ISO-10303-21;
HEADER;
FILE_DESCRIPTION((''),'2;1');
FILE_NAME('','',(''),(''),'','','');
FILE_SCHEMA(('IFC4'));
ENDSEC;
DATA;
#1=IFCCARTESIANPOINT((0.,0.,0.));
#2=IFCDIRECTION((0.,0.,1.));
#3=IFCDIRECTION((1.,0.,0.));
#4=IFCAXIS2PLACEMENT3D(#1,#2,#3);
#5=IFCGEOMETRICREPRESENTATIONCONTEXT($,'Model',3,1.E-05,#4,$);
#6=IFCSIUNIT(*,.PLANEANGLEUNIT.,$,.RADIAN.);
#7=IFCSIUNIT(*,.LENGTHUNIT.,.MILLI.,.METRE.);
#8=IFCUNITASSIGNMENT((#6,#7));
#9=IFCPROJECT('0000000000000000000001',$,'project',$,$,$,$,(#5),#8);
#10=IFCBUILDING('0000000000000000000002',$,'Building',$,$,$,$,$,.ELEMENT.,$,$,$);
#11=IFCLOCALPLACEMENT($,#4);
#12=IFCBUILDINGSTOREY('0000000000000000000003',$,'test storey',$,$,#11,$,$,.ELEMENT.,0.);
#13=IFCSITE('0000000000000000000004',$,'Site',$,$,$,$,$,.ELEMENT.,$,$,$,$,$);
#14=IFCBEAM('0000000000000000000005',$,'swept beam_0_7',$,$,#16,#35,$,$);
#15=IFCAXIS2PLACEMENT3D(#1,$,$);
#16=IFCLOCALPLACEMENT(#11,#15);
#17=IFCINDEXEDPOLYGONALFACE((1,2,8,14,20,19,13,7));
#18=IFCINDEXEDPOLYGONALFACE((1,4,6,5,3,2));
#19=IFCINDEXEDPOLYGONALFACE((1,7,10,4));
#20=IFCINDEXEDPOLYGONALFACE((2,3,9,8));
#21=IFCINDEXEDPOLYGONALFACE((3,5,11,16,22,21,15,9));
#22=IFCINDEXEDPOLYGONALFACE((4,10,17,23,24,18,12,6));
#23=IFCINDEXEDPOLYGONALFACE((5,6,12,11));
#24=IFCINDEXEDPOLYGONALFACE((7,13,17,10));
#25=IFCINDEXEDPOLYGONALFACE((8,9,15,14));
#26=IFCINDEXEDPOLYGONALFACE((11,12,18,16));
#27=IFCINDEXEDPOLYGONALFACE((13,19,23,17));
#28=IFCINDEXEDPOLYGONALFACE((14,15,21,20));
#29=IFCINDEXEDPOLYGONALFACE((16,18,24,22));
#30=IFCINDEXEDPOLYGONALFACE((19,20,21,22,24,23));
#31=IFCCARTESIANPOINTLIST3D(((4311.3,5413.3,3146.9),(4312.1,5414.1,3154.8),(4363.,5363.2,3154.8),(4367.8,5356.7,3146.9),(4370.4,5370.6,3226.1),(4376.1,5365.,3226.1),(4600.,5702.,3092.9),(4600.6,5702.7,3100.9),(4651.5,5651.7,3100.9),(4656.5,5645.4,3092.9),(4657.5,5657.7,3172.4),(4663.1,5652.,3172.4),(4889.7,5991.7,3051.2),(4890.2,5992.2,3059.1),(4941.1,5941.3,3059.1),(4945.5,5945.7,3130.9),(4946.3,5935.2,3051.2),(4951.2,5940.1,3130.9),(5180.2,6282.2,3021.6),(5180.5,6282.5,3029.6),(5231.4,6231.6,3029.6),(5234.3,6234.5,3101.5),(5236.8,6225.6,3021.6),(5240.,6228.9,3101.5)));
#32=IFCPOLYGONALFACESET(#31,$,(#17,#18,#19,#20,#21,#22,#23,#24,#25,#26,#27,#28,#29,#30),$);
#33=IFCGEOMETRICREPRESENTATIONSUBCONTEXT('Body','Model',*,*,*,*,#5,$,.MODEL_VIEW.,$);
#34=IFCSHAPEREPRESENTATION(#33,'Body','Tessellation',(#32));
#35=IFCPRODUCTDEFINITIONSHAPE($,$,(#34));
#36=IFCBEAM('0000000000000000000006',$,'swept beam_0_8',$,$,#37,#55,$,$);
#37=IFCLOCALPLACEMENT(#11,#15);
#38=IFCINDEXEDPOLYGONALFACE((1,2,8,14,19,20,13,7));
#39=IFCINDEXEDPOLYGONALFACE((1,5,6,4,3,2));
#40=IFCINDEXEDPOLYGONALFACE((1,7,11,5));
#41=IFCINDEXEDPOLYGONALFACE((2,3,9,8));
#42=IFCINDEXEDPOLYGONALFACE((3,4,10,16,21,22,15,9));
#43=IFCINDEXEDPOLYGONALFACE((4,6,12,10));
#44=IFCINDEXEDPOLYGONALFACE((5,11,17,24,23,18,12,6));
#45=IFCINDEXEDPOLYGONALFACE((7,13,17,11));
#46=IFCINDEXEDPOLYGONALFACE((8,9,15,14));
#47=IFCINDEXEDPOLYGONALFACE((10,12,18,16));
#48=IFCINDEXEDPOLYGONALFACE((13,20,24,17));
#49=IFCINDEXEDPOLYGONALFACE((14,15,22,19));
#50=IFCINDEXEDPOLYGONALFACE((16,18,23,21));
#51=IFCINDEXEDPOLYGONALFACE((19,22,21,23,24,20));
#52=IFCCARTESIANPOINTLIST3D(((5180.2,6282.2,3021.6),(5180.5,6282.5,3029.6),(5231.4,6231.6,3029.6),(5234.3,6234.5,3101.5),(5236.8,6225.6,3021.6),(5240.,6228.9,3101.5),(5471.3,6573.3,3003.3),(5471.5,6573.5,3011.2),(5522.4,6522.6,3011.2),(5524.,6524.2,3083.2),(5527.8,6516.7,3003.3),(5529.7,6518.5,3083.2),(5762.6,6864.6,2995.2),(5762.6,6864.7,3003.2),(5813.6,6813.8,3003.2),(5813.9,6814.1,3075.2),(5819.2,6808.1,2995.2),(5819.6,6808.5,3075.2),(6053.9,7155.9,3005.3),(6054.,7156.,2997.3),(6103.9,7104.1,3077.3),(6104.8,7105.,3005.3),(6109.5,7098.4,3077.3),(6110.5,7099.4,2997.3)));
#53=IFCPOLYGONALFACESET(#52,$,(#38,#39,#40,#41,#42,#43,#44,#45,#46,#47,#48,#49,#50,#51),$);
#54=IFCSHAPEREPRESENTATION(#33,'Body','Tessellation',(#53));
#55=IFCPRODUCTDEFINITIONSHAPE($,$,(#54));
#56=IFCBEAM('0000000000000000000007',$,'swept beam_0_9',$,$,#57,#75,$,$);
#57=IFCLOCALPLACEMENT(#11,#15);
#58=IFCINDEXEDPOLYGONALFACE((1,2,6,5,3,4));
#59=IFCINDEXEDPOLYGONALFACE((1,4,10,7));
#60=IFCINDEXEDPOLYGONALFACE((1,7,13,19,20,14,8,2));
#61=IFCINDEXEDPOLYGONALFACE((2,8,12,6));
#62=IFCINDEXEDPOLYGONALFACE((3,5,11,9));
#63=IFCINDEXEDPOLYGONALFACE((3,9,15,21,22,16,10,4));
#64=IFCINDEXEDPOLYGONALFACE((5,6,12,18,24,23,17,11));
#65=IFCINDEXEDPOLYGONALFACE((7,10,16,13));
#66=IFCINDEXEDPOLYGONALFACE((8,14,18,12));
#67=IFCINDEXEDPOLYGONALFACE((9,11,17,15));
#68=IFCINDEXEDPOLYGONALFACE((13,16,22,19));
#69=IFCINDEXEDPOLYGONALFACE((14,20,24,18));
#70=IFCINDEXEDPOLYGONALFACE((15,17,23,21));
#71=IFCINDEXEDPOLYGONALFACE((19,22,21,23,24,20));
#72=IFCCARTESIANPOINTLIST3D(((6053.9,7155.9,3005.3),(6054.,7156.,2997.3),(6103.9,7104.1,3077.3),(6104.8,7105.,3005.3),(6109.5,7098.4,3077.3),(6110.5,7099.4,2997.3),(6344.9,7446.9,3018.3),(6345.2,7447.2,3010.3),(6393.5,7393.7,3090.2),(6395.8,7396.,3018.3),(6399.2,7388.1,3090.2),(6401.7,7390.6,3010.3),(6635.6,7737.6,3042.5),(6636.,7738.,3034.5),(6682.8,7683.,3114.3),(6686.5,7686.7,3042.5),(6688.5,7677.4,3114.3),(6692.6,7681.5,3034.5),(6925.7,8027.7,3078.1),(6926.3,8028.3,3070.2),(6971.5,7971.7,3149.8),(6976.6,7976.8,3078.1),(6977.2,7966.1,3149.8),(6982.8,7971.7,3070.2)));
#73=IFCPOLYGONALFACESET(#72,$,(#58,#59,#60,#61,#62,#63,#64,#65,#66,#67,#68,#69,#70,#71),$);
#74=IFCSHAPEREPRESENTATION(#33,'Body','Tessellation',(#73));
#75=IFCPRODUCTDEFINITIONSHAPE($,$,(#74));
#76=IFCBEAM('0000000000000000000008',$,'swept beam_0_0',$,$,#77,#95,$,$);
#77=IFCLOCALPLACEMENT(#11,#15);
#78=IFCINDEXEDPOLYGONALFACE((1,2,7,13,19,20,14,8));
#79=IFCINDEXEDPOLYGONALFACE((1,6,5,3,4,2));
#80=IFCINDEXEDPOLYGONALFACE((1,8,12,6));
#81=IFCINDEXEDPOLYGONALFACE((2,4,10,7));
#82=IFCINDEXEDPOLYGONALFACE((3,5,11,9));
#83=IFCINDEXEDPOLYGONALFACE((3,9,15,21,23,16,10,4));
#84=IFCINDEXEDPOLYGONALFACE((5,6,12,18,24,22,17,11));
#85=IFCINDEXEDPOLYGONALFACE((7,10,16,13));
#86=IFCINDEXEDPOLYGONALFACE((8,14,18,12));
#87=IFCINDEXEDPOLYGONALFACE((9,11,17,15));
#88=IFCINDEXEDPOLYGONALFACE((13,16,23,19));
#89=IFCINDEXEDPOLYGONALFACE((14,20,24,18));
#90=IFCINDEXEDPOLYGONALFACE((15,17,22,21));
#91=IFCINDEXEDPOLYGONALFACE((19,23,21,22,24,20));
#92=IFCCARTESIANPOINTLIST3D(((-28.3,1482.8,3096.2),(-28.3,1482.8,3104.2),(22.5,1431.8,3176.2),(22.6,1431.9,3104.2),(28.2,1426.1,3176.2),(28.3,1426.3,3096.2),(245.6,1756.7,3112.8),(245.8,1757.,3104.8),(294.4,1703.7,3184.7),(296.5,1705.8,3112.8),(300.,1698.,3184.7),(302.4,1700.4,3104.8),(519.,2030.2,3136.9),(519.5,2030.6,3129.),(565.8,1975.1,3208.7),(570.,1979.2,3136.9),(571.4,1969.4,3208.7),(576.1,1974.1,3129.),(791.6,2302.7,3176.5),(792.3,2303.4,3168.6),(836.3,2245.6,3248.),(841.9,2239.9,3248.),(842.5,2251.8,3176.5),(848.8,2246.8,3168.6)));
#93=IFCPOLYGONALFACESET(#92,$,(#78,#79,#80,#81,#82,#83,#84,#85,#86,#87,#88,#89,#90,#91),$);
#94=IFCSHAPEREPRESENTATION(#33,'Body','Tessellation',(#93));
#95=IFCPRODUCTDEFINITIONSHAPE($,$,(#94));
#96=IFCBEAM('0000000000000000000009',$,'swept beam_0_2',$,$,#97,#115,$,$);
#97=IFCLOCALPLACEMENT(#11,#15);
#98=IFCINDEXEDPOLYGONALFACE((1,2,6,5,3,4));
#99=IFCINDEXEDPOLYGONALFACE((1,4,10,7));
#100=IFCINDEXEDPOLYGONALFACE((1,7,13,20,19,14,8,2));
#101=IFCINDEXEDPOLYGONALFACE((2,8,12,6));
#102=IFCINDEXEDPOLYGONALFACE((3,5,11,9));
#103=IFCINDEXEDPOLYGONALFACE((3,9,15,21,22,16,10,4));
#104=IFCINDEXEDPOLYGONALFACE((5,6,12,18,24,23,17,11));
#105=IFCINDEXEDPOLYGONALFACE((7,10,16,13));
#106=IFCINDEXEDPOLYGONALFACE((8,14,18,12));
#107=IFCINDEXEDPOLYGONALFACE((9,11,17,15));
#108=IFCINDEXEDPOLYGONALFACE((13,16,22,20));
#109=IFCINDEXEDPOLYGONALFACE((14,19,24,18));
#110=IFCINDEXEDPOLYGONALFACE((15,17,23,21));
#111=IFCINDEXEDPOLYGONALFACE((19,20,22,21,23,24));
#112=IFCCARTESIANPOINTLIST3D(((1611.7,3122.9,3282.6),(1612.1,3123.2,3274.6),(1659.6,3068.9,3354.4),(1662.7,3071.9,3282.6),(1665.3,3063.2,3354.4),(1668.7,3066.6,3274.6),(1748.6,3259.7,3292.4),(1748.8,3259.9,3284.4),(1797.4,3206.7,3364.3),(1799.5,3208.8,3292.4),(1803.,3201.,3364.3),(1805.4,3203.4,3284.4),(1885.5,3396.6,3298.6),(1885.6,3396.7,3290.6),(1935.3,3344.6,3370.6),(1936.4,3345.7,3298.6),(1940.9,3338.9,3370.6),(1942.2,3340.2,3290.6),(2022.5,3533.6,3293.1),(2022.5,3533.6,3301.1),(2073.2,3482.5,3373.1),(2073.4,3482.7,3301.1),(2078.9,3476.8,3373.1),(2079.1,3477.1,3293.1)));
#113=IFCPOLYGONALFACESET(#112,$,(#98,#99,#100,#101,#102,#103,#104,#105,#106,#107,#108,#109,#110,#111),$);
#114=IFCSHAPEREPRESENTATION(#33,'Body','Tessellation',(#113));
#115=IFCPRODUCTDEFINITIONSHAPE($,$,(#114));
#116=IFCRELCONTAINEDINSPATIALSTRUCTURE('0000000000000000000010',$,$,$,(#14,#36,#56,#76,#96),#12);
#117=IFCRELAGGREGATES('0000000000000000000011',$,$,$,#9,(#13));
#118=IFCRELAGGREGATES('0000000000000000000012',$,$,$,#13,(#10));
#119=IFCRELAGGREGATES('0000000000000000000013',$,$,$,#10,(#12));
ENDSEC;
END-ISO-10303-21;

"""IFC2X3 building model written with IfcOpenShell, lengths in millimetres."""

from ifc_helpers import new_model, entity, si_unit, origin_with_axes, place, context, subcontext, project, spatial, element, save


model = new_model("IFC2X3")

# Units and contexts
model_context = context("Model", 3, precision=1e-05, world=origin_with_axes())
body_context = subcontext(model_context, "Body", "Model", "MODEL_VIEW")
ifc_project = project(units=[si_unit("PLANEANGLEUNIT", "RADIAN"), si_unit("LENGTHUNIT", "METRE", prefix="MILLI")], contexts=[model_context])

# Site, building, storey
site = spatial("IfcSite", under=ifc_project, Name="Site", CompositionType="ELEMENT")
building = spatial("IfcBuilding", under=site, Name="Building", CompositionType="ELEMENT")
storey_placement = place(None, origin_with_axes())
storey = spatial("IfcBuildingStorey", under=building, at=storey_placement, Name="test storey", CompositionType="ELEMENT", Elevation=0.0)

# Beams
beam_1_placement = place(storey_placement, origin_with_axes())
element("IfcBeam", 1, at=beam_1_placement, inside=storey, Name="swept beam_0_7", context=body_context, shape_type="SweptSolid", body=[
    entity("IfcRevolvedAreaSolid", entity("IfcArbitraryClosedProfileDef", "AREA", None, entity("IfcPolyline", [entity("IfcCartesianPoint", [-80.0, 40.0]), entity("IfcCartesianPoint", [-80.0, 32.0]), entity("IfcCartesianPoint", [-8.0, 32.0]), entity("IfcCartesianPoint", [-8.0, -40.0]), entity("IfcCartesianPoint", [0.0, -40.0]), entity("IfcCartesianPoint", [0.0, 40.0]), entity("IfcCartesianPoint", [-80.0, 40.0])])), entity("IfcAxis2Placement3D", entity("IfcCartesianPoint", [4339.5, 5385.0, 3146.9]), entity("IfcDirection", [-0.6995, -0.6995, 0.1458]), entity("IfcDirection", [-0.1031, -0.1031, -0.9893])), entity("IfcAxis1Placement", entity("IfcCartesianPoint", [-13809.9, 0.0, 0.0]), entity("IfcDirection", [0.0, 1.0, 0.0])), 0.089475),
])
beam_2_placement = place(storey_placement, origin_with_axes())
element("IfcBeam", 2, at=beam_2_placement, inside=storey, Name="swept beam_0_8", context=body_context, shape_type="SweptSolid", body=[
    entity("IfcRevolvedAreaSolid", entity("IfcArbitraryClosedProfileDef", "AREA", None, entity("IfcPolyline", [entity("IfcCartesianPoint", [-80.0, 40.0]), entity("IfcCartesianPoint", [-80.0, 32.0]), entity("IfcCartesianPoint", [-8.0, 32.0]), entity("IfcCartesianPoint", [-8.0, -40.0]), entity("IfcCartesianPoint", [0.0, -40.0]), entity("IfcCartesianPoint", [0.0, 40.0]), entity("IfcCartesianPoint", [-80.0, 40.0])])), entity("IfcAxis2Placement3D", entity("IfcCartesianPoint", [5208.5, 6253.9, 3021.6]), entity("IfcDirection", [-0.706, -0.706, 0.0569]), entity("IfcDirection", [-0.0402, -0.0402, -0.9984])), entity("IfcAxis1Placement", entity("IfcCartesianPoint", [-16584.4, 0.0, 0.0]), entity("IfcDirection", [0.0, 1.0, 0.0])), 0.074542),
])
beam_3_placement = place(storey_placement, origin_with_axes())
element("IfcBeam", 3, at=beam_3_placement, inside=storey, Name="swept beam_0_9", context=body_context, shape_type="SweptSolid", body=[
    entity("IfcRevolvedAreaSolid", entity("IfcArbitraryClosedProfileDef", "AREA", None, entity("IfcPolyline", [entity("IfcCartesianPoint", [-80.0, 40.0]), entity("IfcCartesianPoint", [-80.0, 32.0]), entity("IfcCartesianPoint", [-8.0, 32.0]), entity("IfcCartesianPoint", [-8.0, -40.0]), entity("IfcCartesianPoint", [0.0, -40.0]), entity("IfcCartesianPoint", [0.0, 40.0]), entity("IfcCartesianPoint", [-80.0, 40.0])])), entity("IfcAxis2Placement3D", entity("IfcCartesianPoint", [6082.3, 7127.7, 2997.3]), entity("IfcDirection", [-0.707, -0.707, -0.0176]), entity("IfcDirection", [0.0125, 0.0125, -0.9998])), entity("IfcAxis1Placement", entity("IfcCartesianPoint", [-14941.3, 0.0, 0.0]), entity("IfcDirection", [0.0, 1.0, 0.0])), 0.082731),
])
beam_4_placement = place(storey_placement, origin_with_axes())
element("IfcBeam", 4, at=beam_4_placement, inside=storey, Name="swept beam_0_0", context=body_context, shape_type="SweptSolid", body=[
    entity("IfcRevolvedAreaSolid", entity("IfcArbitraryClosedProfileDef", "AREA", None, entity("IfcPolyline", [entity("IfcCartesianPoint", [-80.0, 40.0]), entity("IfcCartesianPoint", [-80.0, 32.0]), entity("IfcCartesianPoint", [-8.0, 32.0]), entity("IfcCartesianPoint", [-8.0, -40.0]), entity("IfcCartesianPoint", [0.0, -40.0]), entity("IfcCartesianPoint", [0.0, 40.0]), entity("IfcCartesianPoint", [-80.0, 40.0])])), entity("IfcAxis2Placement3D", entity("IfcCartesianPoint", [0.0, 1454.5, 3096.2]), entity("IfcDirection", [-0.7071, -0.7071, -0.0022]), entity("IfcDirection", [0.0015, 0.0015, -1.0])), entity("IfcAxis1Placement", entity("IfcCartesianPoint", [-9681.1, 0.0, 0.0]), entity("IfcDirection", [0.0, 1.0, 0.0])), 0.120171),
])
beam_5_placement = place(storey_placement, origin_with_axes())
element("IfcBeam", 5, at=beam_5_placement, inside=storey, Name="swept beam_0_2", context=body_context, shape_type="SweptSolid", body=[
    entity("IfcRevolvedAreaSolid", entity("IfcArbitraryClosedProfileDef", "AREA", None, entity("IfcPolyline", [entity("IfcCartesianPoint", [80.0, -40.0]), entity("IfcCartesianPoint", [80.0, -32.0]), entity("IfcCartesianPoint", [8.0, -32.0]), entity("IfcCartesianPoint", [8.0, 40.0]), entity("IfcCartesianPoint", [0.0, 40.0]), entity("IfcCartesianPoint", [0.0, -40.0]), entity("IfcCartesianPoint", [80.0, -40.0])])), entity("IfcAxis2Placement3D", entity("IfcCartesianPoint", [1640.4, 3094.9, 3274.6]), entity("IfcDirection", [-0.7058, -0.7058, -0.06]), entity("IfcDirection", [-0.0425, -0.0425, 0.9982])), entity("IfcAxis1Placement", entity("IfcCartesianPoint", [-10351.1, 0.0, 0.0]), entity("IfcDirection", [0.0, 1.0, 0.0])), 0.056111),
])

save(model, "model.ifc")
